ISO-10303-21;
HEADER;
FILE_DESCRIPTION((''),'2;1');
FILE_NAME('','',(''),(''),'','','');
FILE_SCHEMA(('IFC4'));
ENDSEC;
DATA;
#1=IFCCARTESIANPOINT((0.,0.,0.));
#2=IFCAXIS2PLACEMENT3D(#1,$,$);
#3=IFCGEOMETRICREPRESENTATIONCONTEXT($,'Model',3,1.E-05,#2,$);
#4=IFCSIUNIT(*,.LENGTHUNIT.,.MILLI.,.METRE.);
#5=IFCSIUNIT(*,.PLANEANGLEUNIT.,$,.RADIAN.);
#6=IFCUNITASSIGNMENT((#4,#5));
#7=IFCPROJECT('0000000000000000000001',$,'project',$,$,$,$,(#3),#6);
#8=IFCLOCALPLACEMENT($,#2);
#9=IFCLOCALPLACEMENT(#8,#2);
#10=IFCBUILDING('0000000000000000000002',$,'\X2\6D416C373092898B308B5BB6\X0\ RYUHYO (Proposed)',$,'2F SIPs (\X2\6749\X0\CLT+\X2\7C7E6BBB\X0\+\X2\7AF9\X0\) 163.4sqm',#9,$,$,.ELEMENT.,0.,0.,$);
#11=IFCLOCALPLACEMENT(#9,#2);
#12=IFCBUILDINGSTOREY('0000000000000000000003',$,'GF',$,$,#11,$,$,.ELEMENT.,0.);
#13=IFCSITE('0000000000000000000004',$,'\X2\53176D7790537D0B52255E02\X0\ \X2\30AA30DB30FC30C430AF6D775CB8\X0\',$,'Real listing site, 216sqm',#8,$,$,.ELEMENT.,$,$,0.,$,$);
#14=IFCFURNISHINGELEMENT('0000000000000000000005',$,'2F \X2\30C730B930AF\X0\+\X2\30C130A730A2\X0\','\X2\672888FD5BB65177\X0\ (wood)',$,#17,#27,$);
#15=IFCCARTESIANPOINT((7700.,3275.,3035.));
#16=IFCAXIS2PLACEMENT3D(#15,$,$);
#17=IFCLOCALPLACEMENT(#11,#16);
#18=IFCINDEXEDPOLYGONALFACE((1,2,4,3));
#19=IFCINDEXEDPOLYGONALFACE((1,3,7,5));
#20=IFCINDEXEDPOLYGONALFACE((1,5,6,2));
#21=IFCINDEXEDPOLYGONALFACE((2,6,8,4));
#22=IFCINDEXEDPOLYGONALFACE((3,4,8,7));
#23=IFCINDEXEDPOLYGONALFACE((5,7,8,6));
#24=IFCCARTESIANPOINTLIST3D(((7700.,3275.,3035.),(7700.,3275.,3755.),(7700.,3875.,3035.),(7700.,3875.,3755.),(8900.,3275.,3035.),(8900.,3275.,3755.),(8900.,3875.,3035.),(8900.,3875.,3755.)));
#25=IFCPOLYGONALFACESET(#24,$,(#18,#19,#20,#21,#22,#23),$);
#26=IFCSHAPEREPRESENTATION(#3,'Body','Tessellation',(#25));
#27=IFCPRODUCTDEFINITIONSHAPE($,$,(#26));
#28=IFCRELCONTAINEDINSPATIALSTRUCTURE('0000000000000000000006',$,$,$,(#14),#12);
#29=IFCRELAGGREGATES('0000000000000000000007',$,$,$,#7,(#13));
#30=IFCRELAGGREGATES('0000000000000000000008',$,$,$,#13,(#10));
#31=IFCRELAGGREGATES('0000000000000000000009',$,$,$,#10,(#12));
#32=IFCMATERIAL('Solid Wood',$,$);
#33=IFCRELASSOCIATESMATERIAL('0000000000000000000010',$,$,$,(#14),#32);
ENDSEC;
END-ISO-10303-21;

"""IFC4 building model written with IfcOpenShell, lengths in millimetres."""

from ifc_helpers import new_model, si_unit, frame, frame_2d, origin, place, context, project, spatial, rectangle, extrude, material, element, save


model = new_model("IFC4")

# Units and contexts
model_context = context("Model", 3, precision=1e-05, world=origin())
ifc_project = project(units=[si_unit("LENGTHUNIT", "METRE", prefix="MILLI"), si_unit("PLANEANGLEUNIT", "RADIAN")], contexts=[model_context])

# Site, building, storey
site_placement = place(None, origin())
site = spatial("IfcSite", under=ifc_project, at=site_placement, Name="北海道紋別市 オホーツク海岸", ObjectType="Real listing site, 216sqm", CompositionType="ELEMENT", RefElevation=0.0)
building_placement = place(site_placement, origin())
building = spatial("IfcBuilding", under=site, at=building_placement, Name="流氷を見る家 RYUHYO (Proposed)", ObjectType="2F SIPs (杉CLT+籾殻+竹) 163.4sqm", CompositionType="ELEMENT", ElevationOfRefHeight=0.0, ElevationOfTerrain=0.0)
storey_placement = place(building_placement, origin())
storey = spatial("IfcBuildingStorey", under=building, at=storey_placement, Name="GF", CompositionType="ELEMENT", Elevation=0.0)

# Shared definitions
ifc_material_1 = material(Name="Solid Wood")

# Furnishing element
furnishing_1_placement = place(storey_placement, frame((7700.0, 3275.0, 3035.0)))
element("IfcFurnishingElement", 1, at=furnishing_1_placement, inside=storey, material=ifc_material_1, Name="2F デスク+チェア", Description="木製家具 (wood)", context=model_context, shape_type="SweptSolid", body=[
    extrude(rectangle(XDim=1200.0, YDim=600.0, at=frame_2d((600.0, 300.0))), frame((7700.0, 3275.0, 3035.0)), (0.0, 0.0, 1.0), 720.0),
])

save(model, "model.ifc")
